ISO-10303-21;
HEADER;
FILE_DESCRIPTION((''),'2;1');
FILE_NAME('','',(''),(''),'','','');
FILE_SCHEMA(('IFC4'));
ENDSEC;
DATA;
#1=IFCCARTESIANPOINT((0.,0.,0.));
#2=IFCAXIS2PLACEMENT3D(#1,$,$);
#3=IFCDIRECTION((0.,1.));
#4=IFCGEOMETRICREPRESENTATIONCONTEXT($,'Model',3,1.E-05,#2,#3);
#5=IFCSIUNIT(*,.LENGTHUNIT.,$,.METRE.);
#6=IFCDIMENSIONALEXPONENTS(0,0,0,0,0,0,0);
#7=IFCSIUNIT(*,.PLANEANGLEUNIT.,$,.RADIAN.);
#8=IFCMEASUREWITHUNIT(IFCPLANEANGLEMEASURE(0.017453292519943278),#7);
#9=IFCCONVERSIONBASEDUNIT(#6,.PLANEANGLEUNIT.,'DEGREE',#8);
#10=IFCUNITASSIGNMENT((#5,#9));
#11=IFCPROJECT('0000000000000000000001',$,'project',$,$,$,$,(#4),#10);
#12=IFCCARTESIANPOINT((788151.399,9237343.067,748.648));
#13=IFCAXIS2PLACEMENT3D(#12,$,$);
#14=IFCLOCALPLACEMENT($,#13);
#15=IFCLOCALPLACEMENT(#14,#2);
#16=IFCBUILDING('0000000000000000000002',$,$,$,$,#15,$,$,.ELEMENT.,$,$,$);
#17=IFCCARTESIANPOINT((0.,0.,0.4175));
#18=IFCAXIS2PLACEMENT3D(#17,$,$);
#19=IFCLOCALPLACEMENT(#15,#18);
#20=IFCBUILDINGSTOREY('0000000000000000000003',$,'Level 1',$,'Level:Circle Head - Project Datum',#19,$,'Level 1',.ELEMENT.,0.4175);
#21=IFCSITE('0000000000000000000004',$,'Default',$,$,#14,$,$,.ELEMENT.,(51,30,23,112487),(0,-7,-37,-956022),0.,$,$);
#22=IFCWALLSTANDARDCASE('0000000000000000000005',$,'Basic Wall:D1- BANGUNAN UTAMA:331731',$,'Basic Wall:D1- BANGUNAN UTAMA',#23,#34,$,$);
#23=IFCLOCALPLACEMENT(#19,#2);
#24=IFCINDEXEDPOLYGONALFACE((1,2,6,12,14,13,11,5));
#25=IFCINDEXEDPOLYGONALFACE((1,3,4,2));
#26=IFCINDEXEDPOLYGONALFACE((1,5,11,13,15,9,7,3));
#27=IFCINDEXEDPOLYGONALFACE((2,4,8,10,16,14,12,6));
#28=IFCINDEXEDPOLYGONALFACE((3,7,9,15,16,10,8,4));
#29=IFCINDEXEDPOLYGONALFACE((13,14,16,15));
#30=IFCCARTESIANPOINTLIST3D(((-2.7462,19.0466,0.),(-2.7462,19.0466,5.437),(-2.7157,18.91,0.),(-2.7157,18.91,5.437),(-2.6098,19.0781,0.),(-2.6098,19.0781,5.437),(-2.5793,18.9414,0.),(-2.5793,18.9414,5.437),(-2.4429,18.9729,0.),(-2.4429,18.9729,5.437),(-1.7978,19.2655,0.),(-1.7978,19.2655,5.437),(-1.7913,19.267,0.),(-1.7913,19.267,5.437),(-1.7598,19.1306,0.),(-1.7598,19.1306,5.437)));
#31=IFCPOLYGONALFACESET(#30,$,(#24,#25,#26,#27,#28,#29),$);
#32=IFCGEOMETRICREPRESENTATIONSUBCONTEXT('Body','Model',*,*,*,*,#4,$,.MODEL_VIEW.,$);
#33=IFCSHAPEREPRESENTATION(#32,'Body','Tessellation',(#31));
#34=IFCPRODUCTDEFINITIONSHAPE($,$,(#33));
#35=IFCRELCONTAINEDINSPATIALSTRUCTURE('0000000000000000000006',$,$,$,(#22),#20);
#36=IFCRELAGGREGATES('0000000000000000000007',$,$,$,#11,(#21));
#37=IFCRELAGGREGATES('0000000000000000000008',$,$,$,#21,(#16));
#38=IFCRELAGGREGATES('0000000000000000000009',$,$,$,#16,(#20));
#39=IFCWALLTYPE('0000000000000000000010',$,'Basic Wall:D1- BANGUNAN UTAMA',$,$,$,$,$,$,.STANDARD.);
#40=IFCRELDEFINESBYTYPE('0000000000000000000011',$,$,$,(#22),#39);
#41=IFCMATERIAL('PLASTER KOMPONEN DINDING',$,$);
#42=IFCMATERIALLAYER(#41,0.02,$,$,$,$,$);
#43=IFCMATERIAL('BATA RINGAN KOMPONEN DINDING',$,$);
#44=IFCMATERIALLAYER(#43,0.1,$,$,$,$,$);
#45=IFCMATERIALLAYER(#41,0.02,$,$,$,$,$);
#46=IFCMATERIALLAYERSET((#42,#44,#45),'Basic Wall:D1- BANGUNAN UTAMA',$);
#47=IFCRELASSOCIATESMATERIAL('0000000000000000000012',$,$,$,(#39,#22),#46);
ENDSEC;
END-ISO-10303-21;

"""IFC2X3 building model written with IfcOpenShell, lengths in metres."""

from ifc_helpers import new_model, entity, si_unit, converted_unit, direction, frame, origin, place, context, subcontext, project, spatial, polyline, outline, extrude, material, layer, layer_set, layer_usage, type_object, element, save


model = new_model("IFC2X3")

# Units and contexts
model_context = context("Model", 3, precision=1e-05, world=origin(), true_north=direction((0.0, 1.0)))
body_context = subcontext(model_context, "Body", "Model", "MODEL_VIEW")
ifc_project = project(units=[si_unit("LENGTHUNIT", "METRE"), converted_unit("PLANEANGLEUNIT", "DEGREE", entity("IfcPlaneAngleMeasure", 0.017453292519943278), si_unit("PLANEANGLEUNIT", "RADIAN"), dimensions=[0, 0, 0, 0, 0, 0, 0])], contexts=[model_context])

# Site, building, storey
site_placement = place(None, frame((788151.399, 9237343.067, 748.648)))
site = spatial("IfcSite", under=ifc_project, at=site_placement, Name="Default", CompositionType="ELEMENT", RefLatitude=(51, 30, 23, 112487), RefLongitude=(0, -7, -37, -956022), RefElevation=0.0)
building_placement = place(site_placement, origin())
building = spatial("IfcBuilding", under=site, at=building_placement, CompositionType="ELEMENT")
storey_placement = place(building_placement, frame((0.0, 0.0, 0.4175)))
storey = spatial("IfcBuildingStorey", under=building, at=storey_placement, Name="Level 1", ObjectType="Level:Circle Head - Project Datum", LongName="Level 1", CompositionType="ELEMENT", Elevation=0.4175)

# Wall
ifc_material_1 = material(Name="PLASTER KOMPONEN DINDING")
ifc_layer_1 = layer(ifc_material_1, 0.02)
ifc_material_2 = material(Name="BATA RINGAN KOMPONEN DINDING")
ifc_layer_2 = layer(ifc_material_2, 0.1)
ifc_layer_3 = layer(ifc_material_1, 0.02)
ifc_layer_set_1 = layer_set([ifc_layer_1, ifc_layer_2, ifc_layer_3], Name="Basic Wall:D1- BANGUNAN UTAMA")
wall_type = type_object("IfcWallType", Name="Basic Wall:D1- BANGUNAN UTAMA", PredefinedType="STANDARD", material=ifc_layer_set_1)
ifc_layer_usage_1 = layer_usage(ifc_layer_set_1, "AXIS2", "POSITIVE", -0.07)
wall_1_placement = place(storey_placement, frame((-1.7755, 19.1988, 0.0), z_axis=(0.0, 0.0, 1.0), x_axis=(-0.974393, -0.224853, 0.0)))
element("IfcWallStandardCase", 1, at=wall_1_placement, inside=storey, type_object=wall_type, material=ifc_layer_usage_1, Name="Basic Wall:D1- BANGUNAN UTAMA:331731", ObjectType="Basic Wall:D1- BANGUNAN UTAMA", context=body_context, shape_type="SweptSolid", body=[
    extrude(outline(polyline([(0.98, -0.07), (0.981, 0.07), (0.841, 0.07), (0.701, 0.07), (0.0, 0.07), (0.0, -0.07), (0.0067, -0.07), (0.84, -0.07), (0.98, -0.07)])), origin(), (0.0, 0.0, 1.0), 5.437),
])

save(model, "model.ifc")
